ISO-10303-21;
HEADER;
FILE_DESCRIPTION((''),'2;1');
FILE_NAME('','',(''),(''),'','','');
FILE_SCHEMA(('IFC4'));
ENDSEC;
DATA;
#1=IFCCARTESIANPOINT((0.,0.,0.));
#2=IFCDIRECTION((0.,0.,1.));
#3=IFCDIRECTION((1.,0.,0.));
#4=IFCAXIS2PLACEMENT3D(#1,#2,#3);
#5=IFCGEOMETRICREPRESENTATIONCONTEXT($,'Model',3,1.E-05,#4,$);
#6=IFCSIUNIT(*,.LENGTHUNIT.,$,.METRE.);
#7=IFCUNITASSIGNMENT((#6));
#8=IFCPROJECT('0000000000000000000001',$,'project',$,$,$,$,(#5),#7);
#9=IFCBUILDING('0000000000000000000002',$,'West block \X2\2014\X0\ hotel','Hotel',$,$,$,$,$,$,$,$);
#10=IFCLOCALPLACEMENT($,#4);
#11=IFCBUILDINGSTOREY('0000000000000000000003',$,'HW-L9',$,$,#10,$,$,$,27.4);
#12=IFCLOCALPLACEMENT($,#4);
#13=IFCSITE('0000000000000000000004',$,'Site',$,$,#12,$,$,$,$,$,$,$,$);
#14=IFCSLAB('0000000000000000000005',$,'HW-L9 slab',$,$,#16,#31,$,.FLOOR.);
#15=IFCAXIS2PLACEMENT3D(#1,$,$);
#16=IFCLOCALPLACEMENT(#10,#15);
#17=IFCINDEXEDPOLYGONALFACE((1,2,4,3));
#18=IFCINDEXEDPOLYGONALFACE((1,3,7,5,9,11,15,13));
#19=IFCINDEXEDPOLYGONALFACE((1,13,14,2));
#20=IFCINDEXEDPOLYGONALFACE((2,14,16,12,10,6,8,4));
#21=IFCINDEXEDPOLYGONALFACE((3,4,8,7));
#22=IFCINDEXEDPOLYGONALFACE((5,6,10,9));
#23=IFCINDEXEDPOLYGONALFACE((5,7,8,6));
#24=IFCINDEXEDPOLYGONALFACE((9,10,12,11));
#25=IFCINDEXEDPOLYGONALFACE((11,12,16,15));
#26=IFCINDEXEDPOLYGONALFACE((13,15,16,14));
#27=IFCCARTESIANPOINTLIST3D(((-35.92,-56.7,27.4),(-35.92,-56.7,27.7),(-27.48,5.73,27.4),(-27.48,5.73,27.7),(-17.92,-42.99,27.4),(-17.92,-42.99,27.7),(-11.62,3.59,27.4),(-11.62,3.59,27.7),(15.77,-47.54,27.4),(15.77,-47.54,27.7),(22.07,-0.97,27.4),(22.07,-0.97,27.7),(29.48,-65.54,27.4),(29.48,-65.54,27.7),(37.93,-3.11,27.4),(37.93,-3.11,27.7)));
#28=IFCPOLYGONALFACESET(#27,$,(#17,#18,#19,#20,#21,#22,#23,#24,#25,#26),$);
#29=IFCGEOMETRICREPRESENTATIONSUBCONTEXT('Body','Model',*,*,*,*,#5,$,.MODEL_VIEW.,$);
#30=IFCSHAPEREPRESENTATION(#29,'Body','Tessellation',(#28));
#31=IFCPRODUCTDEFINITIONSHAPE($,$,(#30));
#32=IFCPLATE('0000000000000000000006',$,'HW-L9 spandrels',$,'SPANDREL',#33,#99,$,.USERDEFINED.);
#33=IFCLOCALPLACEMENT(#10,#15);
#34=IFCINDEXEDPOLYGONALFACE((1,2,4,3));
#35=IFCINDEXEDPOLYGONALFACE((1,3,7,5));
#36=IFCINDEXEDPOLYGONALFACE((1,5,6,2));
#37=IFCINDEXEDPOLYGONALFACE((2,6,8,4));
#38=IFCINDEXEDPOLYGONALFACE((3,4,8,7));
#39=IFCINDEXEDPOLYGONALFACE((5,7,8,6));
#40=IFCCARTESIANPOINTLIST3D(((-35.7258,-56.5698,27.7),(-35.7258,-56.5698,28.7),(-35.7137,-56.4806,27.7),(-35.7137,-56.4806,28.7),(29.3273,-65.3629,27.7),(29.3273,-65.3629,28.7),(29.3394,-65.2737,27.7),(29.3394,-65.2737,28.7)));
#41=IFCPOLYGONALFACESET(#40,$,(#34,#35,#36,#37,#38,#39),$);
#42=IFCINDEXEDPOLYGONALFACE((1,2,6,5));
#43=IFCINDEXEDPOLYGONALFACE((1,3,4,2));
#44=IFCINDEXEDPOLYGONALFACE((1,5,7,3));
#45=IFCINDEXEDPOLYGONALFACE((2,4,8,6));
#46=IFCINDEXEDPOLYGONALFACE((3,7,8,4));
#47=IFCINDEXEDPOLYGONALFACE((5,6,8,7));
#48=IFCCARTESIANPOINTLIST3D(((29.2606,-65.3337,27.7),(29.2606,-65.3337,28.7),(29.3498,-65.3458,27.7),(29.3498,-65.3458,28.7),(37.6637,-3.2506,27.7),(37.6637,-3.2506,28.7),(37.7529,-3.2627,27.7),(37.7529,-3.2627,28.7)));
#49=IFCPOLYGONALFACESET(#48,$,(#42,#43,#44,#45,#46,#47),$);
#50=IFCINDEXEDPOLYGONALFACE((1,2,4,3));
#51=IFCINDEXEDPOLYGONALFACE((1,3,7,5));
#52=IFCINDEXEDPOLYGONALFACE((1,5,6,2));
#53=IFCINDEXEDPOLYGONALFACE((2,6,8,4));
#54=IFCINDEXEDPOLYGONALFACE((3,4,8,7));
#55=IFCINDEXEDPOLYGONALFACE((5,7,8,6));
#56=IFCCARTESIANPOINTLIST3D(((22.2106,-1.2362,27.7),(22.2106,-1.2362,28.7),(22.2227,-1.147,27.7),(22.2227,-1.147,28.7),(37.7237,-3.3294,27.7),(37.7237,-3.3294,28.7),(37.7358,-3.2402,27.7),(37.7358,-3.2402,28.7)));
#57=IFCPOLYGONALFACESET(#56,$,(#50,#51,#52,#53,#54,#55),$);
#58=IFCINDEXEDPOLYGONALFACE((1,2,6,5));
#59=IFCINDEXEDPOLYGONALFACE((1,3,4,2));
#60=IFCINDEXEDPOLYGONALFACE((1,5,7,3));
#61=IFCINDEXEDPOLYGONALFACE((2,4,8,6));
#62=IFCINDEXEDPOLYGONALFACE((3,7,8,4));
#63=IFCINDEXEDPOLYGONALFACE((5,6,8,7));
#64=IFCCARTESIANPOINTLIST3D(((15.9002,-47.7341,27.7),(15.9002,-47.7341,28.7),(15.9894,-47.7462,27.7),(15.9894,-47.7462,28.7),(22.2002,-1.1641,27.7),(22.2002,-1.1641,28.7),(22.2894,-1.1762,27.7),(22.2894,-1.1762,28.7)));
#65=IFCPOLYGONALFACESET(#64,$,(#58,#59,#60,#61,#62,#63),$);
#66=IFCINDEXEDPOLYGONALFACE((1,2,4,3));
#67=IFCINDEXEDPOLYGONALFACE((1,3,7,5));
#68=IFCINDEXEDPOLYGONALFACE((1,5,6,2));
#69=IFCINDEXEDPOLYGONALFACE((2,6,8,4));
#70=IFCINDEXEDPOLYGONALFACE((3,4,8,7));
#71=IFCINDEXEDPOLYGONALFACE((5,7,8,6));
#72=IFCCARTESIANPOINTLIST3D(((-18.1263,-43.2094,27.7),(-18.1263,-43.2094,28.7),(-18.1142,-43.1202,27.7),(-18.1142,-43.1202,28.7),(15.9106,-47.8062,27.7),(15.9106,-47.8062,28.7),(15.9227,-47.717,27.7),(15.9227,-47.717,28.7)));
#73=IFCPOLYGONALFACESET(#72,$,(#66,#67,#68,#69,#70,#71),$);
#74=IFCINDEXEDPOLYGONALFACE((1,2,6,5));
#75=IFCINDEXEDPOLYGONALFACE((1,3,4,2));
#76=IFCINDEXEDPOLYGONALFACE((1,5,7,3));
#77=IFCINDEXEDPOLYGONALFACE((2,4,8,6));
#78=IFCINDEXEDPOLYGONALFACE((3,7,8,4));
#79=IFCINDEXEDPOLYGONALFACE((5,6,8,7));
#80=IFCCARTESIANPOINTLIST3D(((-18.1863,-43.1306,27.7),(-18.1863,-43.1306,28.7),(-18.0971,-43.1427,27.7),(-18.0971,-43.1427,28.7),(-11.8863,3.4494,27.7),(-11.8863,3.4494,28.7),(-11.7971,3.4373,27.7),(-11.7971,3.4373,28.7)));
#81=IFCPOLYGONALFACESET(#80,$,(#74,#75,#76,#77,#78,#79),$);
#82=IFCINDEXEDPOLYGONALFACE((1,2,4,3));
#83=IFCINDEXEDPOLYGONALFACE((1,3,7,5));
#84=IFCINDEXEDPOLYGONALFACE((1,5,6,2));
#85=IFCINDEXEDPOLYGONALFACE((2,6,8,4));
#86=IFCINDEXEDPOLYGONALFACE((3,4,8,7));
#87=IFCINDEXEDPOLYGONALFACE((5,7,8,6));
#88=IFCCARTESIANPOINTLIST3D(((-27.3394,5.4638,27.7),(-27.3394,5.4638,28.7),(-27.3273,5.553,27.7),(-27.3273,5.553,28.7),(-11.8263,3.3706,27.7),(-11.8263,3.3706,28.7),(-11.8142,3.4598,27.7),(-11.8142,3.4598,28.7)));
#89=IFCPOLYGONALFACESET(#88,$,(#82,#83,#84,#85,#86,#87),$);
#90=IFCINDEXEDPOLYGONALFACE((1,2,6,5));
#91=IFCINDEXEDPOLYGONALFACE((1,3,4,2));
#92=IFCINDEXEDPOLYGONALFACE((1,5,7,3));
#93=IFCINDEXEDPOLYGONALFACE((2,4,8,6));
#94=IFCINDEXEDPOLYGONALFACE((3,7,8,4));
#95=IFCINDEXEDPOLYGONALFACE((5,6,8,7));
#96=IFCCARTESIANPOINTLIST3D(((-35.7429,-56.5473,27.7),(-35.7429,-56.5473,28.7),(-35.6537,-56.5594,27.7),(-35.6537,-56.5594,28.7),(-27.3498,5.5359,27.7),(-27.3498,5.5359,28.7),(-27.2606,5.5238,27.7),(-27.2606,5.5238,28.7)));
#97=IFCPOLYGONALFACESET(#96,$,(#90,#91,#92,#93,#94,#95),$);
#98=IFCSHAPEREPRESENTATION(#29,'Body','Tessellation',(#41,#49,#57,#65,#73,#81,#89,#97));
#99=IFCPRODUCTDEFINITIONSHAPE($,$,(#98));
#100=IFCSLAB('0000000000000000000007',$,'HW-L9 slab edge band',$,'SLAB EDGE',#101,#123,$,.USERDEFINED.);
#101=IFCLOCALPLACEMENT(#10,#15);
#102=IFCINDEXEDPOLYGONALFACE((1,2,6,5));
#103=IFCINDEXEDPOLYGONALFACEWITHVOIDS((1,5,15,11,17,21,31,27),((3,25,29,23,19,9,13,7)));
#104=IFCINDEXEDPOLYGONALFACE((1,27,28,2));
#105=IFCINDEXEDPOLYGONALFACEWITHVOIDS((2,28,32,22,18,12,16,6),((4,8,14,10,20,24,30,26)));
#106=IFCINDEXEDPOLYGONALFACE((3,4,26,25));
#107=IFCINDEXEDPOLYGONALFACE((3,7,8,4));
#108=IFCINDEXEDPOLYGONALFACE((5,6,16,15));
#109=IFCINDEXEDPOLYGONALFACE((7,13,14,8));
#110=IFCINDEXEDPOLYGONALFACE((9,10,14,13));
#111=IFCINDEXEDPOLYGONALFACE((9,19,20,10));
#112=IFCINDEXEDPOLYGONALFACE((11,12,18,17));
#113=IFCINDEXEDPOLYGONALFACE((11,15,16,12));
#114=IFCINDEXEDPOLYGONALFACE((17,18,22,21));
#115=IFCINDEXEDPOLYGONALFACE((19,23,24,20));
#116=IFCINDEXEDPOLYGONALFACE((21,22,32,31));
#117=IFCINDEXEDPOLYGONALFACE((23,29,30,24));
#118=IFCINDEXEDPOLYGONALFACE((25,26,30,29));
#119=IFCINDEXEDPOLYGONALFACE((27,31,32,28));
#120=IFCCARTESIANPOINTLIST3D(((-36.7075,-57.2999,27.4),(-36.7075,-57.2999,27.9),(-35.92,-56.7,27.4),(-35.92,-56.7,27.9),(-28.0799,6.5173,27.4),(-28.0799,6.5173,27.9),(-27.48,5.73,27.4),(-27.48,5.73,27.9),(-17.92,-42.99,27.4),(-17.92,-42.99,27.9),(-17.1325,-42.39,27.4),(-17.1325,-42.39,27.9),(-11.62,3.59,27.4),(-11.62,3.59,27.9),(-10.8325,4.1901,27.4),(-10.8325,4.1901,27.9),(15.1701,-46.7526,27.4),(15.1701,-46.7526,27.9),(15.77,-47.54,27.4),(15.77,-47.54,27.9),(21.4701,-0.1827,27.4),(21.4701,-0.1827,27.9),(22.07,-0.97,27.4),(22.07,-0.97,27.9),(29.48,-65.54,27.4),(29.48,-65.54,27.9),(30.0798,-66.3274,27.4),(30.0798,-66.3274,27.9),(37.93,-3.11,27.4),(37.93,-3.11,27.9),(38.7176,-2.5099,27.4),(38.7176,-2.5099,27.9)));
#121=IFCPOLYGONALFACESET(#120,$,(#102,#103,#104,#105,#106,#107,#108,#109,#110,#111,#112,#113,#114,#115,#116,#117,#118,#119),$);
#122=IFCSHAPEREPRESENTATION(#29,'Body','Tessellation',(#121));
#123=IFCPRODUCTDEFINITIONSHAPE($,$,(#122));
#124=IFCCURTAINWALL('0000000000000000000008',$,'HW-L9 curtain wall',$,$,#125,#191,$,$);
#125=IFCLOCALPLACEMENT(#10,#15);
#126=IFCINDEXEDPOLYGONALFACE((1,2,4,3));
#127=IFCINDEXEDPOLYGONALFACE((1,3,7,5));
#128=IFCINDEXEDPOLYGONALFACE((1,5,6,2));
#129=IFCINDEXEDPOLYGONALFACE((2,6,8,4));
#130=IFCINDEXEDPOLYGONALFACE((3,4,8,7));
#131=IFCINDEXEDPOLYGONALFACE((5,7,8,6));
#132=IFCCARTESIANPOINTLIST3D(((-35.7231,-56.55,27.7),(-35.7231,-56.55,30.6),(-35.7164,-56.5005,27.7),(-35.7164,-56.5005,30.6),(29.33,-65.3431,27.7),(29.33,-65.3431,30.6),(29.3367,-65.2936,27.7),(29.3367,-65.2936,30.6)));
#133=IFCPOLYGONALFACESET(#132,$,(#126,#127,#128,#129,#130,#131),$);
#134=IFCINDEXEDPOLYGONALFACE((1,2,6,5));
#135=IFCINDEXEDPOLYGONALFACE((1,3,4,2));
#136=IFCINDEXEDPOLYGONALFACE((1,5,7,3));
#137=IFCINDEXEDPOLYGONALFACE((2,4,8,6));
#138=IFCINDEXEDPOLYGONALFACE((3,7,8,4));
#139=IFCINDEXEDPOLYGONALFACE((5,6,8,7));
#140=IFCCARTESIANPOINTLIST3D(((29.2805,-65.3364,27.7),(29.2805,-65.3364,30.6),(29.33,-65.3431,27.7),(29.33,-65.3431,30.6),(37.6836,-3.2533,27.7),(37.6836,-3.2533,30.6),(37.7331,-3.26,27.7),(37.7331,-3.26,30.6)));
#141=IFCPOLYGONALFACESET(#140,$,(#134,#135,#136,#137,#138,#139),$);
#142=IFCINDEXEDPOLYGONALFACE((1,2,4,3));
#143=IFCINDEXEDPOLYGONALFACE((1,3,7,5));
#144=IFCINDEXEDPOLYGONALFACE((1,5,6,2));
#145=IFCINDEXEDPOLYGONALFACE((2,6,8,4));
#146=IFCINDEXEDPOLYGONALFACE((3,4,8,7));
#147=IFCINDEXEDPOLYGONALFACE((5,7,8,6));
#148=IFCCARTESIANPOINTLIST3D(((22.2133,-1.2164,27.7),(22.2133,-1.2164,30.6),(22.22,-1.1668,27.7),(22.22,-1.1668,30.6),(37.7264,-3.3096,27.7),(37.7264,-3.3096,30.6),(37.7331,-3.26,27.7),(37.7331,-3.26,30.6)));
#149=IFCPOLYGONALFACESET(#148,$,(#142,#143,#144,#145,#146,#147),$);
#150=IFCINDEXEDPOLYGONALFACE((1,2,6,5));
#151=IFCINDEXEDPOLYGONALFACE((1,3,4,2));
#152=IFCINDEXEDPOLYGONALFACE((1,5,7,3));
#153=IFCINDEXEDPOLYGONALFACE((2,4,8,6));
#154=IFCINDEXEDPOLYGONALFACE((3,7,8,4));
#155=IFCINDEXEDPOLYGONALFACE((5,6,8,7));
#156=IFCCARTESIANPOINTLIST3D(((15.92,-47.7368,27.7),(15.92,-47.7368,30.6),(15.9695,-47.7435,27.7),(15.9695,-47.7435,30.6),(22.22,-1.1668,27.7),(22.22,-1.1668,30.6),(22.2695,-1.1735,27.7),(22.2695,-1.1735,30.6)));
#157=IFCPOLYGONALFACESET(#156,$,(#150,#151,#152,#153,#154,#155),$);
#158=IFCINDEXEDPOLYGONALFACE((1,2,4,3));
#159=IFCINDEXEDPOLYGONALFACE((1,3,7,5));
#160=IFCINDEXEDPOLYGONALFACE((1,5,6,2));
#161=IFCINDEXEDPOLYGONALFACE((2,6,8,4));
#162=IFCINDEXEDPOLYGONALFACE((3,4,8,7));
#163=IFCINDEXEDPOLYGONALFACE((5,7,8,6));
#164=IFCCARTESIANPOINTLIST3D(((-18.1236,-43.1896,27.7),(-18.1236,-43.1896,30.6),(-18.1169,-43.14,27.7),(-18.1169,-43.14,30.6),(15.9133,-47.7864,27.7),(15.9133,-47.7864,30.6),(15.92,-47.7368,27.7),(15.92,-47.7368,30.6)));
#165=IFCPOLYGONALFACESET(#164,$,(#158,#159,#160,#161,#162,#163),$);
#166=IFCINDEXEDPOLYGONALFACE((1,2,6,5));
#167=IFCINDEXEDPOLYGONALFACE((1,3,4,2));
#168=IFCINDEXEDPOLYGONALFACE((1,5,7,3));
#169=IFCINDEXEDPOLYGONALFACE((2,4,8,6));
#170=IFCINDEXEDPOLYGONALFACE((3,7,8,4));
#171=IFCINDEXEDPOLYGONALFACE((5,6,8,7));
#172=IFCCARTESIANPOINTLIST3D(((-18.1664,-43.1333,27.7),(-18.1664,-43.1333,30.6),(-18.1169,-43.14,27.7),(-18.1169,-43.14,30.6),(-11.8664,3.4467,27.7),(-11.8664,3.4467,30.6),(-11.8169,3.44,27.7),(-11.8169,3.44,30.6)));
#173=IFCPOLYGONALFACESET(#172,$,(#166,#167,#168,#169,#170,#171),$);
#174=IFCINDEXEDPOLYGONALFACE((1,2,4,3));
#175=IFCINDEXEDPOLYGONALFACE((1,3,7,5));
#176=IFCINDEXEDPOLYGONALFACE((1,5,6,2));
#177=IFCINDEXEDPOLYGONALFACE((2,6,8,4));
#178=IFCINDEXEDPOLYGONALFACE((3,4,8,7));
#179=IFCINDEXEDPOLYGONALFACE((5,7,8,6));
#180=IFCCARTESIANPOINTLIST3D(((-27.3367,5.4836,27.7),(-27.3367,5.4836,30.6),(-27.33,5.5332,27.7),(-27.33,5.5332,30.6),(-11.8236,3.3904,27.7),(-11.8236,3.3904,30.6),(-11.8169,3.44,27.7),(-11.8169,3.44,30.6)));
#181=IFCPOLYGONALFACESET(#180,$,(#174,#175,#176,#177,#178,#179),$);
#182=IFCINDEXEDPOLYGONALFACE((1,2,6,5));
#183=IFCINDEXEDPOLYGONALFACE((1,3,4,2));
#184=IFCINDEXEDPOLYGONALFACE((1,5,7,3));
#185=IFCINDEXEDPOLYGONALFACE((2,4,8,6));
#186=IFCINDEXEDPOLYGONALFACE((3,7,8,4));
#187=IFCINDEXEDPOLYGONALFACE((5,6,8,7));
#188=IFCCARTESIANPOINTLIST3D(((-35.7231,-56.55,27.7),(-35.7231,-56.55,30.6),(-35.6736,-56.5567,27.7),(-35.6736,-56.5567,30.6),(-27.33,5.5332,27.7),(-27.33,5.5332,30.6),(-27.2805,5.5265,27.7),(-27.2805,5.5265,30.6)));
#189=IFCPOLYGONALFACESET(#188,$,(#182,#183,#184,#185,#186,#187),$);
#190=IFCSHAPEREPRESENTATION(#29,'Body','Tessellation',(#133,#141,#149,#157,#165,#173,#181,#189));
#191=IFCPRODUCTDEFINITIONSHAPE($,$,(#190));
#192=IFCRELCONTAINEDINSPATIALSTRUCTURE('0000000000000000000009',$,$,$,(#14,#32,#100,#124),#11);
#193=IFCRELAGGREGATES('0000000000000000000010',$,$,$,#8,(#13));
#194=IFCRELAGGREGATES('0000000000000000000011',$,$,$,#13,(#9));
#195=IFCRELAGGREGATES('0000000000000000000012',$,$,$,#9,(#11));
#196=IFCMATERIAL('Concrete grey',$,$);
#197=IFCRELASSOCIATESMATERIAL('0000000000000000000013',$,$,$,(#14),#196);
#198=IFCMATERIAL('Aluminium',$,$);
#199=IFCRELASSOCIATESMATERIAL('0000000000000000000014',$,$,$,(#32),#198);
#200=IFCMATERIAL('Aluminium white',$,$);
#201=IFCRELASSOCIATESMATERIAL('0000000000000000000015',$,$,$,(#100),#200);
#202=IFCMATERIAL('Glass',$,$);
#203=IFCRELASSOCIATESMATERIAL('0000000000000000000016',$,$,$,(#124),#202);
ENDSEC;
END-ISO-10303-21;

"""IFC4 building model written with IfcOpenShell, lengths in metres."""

from ifc_helpers import new_model, si_unit, frame, origin_with_axes, place, context, subcontext, project, spatial, polyline, outline, extrude, material, element, save


model = new_model("IFC4")

# Units and contexts
model_context = context("Model", 3, precision=1e-05, world=origin_with_axes())
body_context = subcontext(model_context, "Body", "Model", "MODEL_VIEW")
ifc_project = project(units=[si_unit("LENGTHUNIT", "METRE")], contexts=[model_context])

# Site, building, storey
site_placement = place(None, origin_with_axes())
site = spatial("IfcSite", under=ifc_project, at=site_placement, Name="Site")
building = spatial("IfcBuilding", under=site, Name="West block — hotel", Description="Hotel")
storey_placement = place(None, origin_with_axes())
storey = spatial("IfcBuildingStorey", under=building, at=storey_placement, Name="HW-L9", Elevation=27.4)

# Shared definitions
ifc_material_1 = material(Name="Aluminium")

# Slab
ifc_material_2 = material(Name="Concrete grey")
slab_1_placement = place(storey_placement, origin_with_axes())
element("IfcSlab", 1, at=slab_1_placement, inside=storey, material=ifc_material_2, Name="HW-L9 slab", PredefinedType="FLOOR", context=body_context, shape_type="SweptSolid", body=[
    extrude(outline(polyline([(-35.92, -56.7), (29.48, -65.54), (37.93, -3.11), (22.07, -0.97), (15.77, -47.54), (-17.92, -42.99), (-11.62, 3.59), (-27.48, 5.73), (-35.92, -56.7)])), frame((0.0, 0.0, 27.4), z_axis=(0.0, 0.0, 1.0), x_axis=(1.0, 0.0, 0.0)), (0.0, 0.0, 1.0), 0.3),
])

# Plate
plate_placement = place(storey_placement, origin_with_axes())
element("IfcPlate", 2, at=plate_placement, inside=storey, material=ifc_material_1, Name="HW-L9 spandrels", ObjectType="SPANDREL", PredefinedType="USERDEFINED", context=body_context, shape_type="SweptSolid", body=[
    extrude(outline(polyline([(-35.7258, -56.5698), (29.3273, -65.3629), (29.3394, -65.2737), (-35.7137, -56.4806), (-35.7258, -56.5698)])), frame((0.0, 0.0, 27.7), z_axis=(0.0, 0.0, 1.0), x_axis=(1.0, 0.0, 0.0)), (0.0, 0.0, 1.0), 1.0),
    extrude(outline(polyline([(29.3498, -65.3458), (37.7529, -3.2627), (37.6637, -3.2506), (29.2606, -65.3337), (29.3498, -65.3458)])), frame((0.0, 0.0, 27.7), z_axis=(0.0, 0.0, 1.0), x_axis=(1.0, 0.0, 0.0)), (0.0, 0.0, 1.0), 1.0),
    extrude(outline(polyline([(37.7358, -3.2402), (22.2227, -1.147), (22.2106, -1.2362), (37.7237, -3.3294), (37.7358, -3.2402)])), frame((0.0, 0.0, 27.7), z_axis=(0.0, 0.0, 1.0), x_axis=(1.0, 0.0, 0.0)), (0.0, 0.0, 1.0), 1.0),
    extrude(outline(polyline([(22.2002, -1.1641), (15.9002, -47.7341), (15.9894, -47.7462), (22.2894, -1.1762), (22.2002, -1.1641)])), frame((0.0, 0.0, 27.7), z_axis=(0.0, 0.0, 1.0), x_axis=(1.0, 0.0, 0.0)), (0.0, 0.0, 1.0), 1.0),
    extrude(outline(polyline([(15.9227, -47.717), (-18.1142, -43.1202), (-18.1263, -43.2094), (15.9106, -47.8062), (15.9227, -47.717)])), frame((0.0, 0.0, 27.7), z_axis=(0.0, 0.0, 1.0), x_axis=(1.0, 0.0, 0.0)), (0.0, 0.0, 1.0), 1.0),
    extrude(outline(polyline([(-18.0971, -43.1427), (-11.7971, 3.4373), (-11.8863, 3.4494), (-18.1863, -43.1306), (-18.0971, -43.1427)])), frame((0.0, 0.0, 27.7), z_axis=(0.0, 0.0, 1.0), x_axis=(1.0, 0.0, 0.0)), (0.0, 0.0, 1.0), 1.0),
    extrude(outline(polyline([(-11.8142, 3.4598), (-27.3273, 5.553), (-27.3394, 5.4638), (-11.8263, 3.3706), (-11.8142, 3.4598)])), frame((0.0, 0.0, 27.7), z_axis=(0.0, 0.0, 1.0), x_axis=(1.0, 0.0, 0.0)), (0.0, 0.0, 1.0), 1.0),
    extrude(outline(polyline([(-27.3498, 5.5359), (-35.7429, -56.5473), (-35.6537, -56.5594), (-27.2606, 5.5238), (-27.3498, 5.5359)])), frame((0.0, 0.0, 27.7), z_axis=(0.0, 0.0, 1.0), x_axis=(1.0, 0.0, 0.0)), (0.0, 0.0, 1.0), 1.0),
])

# Slab
ifc_material_3 = material(Name="Aluminium white")
slab_2_placement = place(storey_placement, origin_with_axes())
element("IfcSlab", 3, at=slab_2_placement, inside=storey, material=ifc_material_3, Name="HW-L9 slab edge band", ObjectType="SLAB EDGE", PredefinedType="USERDEFINED", context=body_context, shape_type="SweptSolid", body=[
    extrude(outline(polyline([(-36.7075, -57.2999), (30.0798, -66.3274), (38.7176, -2.5099), (21.4701, -0.1827), (15.1701, -46.7526), (-17.1325, -42.39), (-10.8325, 4.1901), (-28.0799, 6.5173), (-36.7075, -57.2999)]), holes=[polyline([(-35.92, -56.7), (29.48, -65.54), (37.93, -3.11), (22.07, -0.97), (15.77, -47.54), (-17.92, -42.99), (-11.62, 3.59), (-27.48, 5.73), (-35.92, -56.7)])]), frame((0.0, 0.0, 27.4), z_axis=(0.0, 0.0, 1.0), x_axis=(1.0, 0.0, 0.0)), (0.0, 0.0, 1.0), 0.5),
])

# Curtain wall
ifc_material_4 = material(Name="Glass")
curtain_wall_placement = place(storey_placement, origin_with_axes())
element("IfcCurtainWall", 4, at=curtain_wall_placement, inside=storey, material=ifc_material_4, Name="HW-L9 curtain wall", context=body_context, shape_type="SweptSolid", body=[
    extrude(outline(polyline([(-35.7231, -56.55), (29.33, -65.3431), (29.3367, -65.2936), (-35.7164, -56.5005), (-35.7231, -56.55)])), frame((0.0, 0.0, 27.7), z_axis=(0.0, 0.0, 1.0), x_axis=(1.0, 0.0, 0.0)), (0.0, 0.0, 1.0), 2.9),
    extrude(outline(polyline([(29.33, -65.3431), (37.7331, -3.26), (37.6836, -3.2533), (29.2805, -65.3364), (29.33, -65.3431)])), frame((0.0, 0.0, 27.7), z_axis=(0.0, 0.0, 1.0), x_axis=(1.0, 0.0, 0.0)), (0.0, 0.0, 1.0), 2.9),
    extrude(outline(polyline([(37.7331, -3.26), (22.22, -1.1668), (22.2133, -1.2164), (37.7264, -3.3096), (37.7331, -3.26)])), frame((0.0, 0.0, 27.7), z_axis=(0.0, 0.0, 1.0), x_axis=(1.0, 0.0, 0.0)), (0.0, 0.0, 1.0), 2.9),
    extrude(outline(polyline([(22.22, -1.1668), (15.92, -47.7368), (15.9695, -47.7435), (22.2695, -1.1735), (22.22, -1.1668)])), frame((0.0, 0.0, 27.7), z_axis=(0.0, 0.0, 1.0), x_axis=(1.0, 0.0, 0.0)), (0.0, 0.0, 1.0), 2.9),
    extrude(outline(polyline([(15.92, -47.7368), (-18.1169, -43.14), (-18.1236, -43.1896), (15.9133, -47.7864), (15.92, -47.7368)])), frame((0.0, 0.0, 27.7), z_axis=(0.0, 0.0, 1.0), x_axis=(1.0, 0.0, 0.0)), (0.0, 0.0, 1.0), 2.9),
    extrude(outline(polyline([(-18.1169, -43.14), (-11.8169, 3.44), (-11.8664, 3.4467), (-18.1664, -43.1333), (-18.1169, -43.14)])), frame((0.0, 0.0, 27.7), z_axis=(0.0, 0.0, 1.0), x_axis=(1.0, 0.0, 0.0)), (0.0, 0.0, 1.0), 2.9),
    extrude(outline(polyline([(-11.8169, 3.44), (-27.33, 5.5332), (-27.3367, 5.4836), (-11.8236, 3.3904), (-11.8169, 3.44)])), frame((0.0, 0.0, 27.7), z_axis=(0.0, 0.0, 1.0), x_axis=(1.0, 0.0, 0.0)), (0.0, 0.0, 1.0), 2.9),
    extrude(outline(polyline([(-27.33, 5.5332), (-35.7231, -56.55), (-35.6736, -56.5567), (-27.2805, 5.5265), (-27.33, 5.5332)])), frame((0.0, 0.0, 27.7), z_axis=(0.0, 0.0, 1.0), x_axis=(1.0, 0.0, 0.0)), (0.0, 0.0, 1.0), 2.9),
])

save(model, "model.ifc")
